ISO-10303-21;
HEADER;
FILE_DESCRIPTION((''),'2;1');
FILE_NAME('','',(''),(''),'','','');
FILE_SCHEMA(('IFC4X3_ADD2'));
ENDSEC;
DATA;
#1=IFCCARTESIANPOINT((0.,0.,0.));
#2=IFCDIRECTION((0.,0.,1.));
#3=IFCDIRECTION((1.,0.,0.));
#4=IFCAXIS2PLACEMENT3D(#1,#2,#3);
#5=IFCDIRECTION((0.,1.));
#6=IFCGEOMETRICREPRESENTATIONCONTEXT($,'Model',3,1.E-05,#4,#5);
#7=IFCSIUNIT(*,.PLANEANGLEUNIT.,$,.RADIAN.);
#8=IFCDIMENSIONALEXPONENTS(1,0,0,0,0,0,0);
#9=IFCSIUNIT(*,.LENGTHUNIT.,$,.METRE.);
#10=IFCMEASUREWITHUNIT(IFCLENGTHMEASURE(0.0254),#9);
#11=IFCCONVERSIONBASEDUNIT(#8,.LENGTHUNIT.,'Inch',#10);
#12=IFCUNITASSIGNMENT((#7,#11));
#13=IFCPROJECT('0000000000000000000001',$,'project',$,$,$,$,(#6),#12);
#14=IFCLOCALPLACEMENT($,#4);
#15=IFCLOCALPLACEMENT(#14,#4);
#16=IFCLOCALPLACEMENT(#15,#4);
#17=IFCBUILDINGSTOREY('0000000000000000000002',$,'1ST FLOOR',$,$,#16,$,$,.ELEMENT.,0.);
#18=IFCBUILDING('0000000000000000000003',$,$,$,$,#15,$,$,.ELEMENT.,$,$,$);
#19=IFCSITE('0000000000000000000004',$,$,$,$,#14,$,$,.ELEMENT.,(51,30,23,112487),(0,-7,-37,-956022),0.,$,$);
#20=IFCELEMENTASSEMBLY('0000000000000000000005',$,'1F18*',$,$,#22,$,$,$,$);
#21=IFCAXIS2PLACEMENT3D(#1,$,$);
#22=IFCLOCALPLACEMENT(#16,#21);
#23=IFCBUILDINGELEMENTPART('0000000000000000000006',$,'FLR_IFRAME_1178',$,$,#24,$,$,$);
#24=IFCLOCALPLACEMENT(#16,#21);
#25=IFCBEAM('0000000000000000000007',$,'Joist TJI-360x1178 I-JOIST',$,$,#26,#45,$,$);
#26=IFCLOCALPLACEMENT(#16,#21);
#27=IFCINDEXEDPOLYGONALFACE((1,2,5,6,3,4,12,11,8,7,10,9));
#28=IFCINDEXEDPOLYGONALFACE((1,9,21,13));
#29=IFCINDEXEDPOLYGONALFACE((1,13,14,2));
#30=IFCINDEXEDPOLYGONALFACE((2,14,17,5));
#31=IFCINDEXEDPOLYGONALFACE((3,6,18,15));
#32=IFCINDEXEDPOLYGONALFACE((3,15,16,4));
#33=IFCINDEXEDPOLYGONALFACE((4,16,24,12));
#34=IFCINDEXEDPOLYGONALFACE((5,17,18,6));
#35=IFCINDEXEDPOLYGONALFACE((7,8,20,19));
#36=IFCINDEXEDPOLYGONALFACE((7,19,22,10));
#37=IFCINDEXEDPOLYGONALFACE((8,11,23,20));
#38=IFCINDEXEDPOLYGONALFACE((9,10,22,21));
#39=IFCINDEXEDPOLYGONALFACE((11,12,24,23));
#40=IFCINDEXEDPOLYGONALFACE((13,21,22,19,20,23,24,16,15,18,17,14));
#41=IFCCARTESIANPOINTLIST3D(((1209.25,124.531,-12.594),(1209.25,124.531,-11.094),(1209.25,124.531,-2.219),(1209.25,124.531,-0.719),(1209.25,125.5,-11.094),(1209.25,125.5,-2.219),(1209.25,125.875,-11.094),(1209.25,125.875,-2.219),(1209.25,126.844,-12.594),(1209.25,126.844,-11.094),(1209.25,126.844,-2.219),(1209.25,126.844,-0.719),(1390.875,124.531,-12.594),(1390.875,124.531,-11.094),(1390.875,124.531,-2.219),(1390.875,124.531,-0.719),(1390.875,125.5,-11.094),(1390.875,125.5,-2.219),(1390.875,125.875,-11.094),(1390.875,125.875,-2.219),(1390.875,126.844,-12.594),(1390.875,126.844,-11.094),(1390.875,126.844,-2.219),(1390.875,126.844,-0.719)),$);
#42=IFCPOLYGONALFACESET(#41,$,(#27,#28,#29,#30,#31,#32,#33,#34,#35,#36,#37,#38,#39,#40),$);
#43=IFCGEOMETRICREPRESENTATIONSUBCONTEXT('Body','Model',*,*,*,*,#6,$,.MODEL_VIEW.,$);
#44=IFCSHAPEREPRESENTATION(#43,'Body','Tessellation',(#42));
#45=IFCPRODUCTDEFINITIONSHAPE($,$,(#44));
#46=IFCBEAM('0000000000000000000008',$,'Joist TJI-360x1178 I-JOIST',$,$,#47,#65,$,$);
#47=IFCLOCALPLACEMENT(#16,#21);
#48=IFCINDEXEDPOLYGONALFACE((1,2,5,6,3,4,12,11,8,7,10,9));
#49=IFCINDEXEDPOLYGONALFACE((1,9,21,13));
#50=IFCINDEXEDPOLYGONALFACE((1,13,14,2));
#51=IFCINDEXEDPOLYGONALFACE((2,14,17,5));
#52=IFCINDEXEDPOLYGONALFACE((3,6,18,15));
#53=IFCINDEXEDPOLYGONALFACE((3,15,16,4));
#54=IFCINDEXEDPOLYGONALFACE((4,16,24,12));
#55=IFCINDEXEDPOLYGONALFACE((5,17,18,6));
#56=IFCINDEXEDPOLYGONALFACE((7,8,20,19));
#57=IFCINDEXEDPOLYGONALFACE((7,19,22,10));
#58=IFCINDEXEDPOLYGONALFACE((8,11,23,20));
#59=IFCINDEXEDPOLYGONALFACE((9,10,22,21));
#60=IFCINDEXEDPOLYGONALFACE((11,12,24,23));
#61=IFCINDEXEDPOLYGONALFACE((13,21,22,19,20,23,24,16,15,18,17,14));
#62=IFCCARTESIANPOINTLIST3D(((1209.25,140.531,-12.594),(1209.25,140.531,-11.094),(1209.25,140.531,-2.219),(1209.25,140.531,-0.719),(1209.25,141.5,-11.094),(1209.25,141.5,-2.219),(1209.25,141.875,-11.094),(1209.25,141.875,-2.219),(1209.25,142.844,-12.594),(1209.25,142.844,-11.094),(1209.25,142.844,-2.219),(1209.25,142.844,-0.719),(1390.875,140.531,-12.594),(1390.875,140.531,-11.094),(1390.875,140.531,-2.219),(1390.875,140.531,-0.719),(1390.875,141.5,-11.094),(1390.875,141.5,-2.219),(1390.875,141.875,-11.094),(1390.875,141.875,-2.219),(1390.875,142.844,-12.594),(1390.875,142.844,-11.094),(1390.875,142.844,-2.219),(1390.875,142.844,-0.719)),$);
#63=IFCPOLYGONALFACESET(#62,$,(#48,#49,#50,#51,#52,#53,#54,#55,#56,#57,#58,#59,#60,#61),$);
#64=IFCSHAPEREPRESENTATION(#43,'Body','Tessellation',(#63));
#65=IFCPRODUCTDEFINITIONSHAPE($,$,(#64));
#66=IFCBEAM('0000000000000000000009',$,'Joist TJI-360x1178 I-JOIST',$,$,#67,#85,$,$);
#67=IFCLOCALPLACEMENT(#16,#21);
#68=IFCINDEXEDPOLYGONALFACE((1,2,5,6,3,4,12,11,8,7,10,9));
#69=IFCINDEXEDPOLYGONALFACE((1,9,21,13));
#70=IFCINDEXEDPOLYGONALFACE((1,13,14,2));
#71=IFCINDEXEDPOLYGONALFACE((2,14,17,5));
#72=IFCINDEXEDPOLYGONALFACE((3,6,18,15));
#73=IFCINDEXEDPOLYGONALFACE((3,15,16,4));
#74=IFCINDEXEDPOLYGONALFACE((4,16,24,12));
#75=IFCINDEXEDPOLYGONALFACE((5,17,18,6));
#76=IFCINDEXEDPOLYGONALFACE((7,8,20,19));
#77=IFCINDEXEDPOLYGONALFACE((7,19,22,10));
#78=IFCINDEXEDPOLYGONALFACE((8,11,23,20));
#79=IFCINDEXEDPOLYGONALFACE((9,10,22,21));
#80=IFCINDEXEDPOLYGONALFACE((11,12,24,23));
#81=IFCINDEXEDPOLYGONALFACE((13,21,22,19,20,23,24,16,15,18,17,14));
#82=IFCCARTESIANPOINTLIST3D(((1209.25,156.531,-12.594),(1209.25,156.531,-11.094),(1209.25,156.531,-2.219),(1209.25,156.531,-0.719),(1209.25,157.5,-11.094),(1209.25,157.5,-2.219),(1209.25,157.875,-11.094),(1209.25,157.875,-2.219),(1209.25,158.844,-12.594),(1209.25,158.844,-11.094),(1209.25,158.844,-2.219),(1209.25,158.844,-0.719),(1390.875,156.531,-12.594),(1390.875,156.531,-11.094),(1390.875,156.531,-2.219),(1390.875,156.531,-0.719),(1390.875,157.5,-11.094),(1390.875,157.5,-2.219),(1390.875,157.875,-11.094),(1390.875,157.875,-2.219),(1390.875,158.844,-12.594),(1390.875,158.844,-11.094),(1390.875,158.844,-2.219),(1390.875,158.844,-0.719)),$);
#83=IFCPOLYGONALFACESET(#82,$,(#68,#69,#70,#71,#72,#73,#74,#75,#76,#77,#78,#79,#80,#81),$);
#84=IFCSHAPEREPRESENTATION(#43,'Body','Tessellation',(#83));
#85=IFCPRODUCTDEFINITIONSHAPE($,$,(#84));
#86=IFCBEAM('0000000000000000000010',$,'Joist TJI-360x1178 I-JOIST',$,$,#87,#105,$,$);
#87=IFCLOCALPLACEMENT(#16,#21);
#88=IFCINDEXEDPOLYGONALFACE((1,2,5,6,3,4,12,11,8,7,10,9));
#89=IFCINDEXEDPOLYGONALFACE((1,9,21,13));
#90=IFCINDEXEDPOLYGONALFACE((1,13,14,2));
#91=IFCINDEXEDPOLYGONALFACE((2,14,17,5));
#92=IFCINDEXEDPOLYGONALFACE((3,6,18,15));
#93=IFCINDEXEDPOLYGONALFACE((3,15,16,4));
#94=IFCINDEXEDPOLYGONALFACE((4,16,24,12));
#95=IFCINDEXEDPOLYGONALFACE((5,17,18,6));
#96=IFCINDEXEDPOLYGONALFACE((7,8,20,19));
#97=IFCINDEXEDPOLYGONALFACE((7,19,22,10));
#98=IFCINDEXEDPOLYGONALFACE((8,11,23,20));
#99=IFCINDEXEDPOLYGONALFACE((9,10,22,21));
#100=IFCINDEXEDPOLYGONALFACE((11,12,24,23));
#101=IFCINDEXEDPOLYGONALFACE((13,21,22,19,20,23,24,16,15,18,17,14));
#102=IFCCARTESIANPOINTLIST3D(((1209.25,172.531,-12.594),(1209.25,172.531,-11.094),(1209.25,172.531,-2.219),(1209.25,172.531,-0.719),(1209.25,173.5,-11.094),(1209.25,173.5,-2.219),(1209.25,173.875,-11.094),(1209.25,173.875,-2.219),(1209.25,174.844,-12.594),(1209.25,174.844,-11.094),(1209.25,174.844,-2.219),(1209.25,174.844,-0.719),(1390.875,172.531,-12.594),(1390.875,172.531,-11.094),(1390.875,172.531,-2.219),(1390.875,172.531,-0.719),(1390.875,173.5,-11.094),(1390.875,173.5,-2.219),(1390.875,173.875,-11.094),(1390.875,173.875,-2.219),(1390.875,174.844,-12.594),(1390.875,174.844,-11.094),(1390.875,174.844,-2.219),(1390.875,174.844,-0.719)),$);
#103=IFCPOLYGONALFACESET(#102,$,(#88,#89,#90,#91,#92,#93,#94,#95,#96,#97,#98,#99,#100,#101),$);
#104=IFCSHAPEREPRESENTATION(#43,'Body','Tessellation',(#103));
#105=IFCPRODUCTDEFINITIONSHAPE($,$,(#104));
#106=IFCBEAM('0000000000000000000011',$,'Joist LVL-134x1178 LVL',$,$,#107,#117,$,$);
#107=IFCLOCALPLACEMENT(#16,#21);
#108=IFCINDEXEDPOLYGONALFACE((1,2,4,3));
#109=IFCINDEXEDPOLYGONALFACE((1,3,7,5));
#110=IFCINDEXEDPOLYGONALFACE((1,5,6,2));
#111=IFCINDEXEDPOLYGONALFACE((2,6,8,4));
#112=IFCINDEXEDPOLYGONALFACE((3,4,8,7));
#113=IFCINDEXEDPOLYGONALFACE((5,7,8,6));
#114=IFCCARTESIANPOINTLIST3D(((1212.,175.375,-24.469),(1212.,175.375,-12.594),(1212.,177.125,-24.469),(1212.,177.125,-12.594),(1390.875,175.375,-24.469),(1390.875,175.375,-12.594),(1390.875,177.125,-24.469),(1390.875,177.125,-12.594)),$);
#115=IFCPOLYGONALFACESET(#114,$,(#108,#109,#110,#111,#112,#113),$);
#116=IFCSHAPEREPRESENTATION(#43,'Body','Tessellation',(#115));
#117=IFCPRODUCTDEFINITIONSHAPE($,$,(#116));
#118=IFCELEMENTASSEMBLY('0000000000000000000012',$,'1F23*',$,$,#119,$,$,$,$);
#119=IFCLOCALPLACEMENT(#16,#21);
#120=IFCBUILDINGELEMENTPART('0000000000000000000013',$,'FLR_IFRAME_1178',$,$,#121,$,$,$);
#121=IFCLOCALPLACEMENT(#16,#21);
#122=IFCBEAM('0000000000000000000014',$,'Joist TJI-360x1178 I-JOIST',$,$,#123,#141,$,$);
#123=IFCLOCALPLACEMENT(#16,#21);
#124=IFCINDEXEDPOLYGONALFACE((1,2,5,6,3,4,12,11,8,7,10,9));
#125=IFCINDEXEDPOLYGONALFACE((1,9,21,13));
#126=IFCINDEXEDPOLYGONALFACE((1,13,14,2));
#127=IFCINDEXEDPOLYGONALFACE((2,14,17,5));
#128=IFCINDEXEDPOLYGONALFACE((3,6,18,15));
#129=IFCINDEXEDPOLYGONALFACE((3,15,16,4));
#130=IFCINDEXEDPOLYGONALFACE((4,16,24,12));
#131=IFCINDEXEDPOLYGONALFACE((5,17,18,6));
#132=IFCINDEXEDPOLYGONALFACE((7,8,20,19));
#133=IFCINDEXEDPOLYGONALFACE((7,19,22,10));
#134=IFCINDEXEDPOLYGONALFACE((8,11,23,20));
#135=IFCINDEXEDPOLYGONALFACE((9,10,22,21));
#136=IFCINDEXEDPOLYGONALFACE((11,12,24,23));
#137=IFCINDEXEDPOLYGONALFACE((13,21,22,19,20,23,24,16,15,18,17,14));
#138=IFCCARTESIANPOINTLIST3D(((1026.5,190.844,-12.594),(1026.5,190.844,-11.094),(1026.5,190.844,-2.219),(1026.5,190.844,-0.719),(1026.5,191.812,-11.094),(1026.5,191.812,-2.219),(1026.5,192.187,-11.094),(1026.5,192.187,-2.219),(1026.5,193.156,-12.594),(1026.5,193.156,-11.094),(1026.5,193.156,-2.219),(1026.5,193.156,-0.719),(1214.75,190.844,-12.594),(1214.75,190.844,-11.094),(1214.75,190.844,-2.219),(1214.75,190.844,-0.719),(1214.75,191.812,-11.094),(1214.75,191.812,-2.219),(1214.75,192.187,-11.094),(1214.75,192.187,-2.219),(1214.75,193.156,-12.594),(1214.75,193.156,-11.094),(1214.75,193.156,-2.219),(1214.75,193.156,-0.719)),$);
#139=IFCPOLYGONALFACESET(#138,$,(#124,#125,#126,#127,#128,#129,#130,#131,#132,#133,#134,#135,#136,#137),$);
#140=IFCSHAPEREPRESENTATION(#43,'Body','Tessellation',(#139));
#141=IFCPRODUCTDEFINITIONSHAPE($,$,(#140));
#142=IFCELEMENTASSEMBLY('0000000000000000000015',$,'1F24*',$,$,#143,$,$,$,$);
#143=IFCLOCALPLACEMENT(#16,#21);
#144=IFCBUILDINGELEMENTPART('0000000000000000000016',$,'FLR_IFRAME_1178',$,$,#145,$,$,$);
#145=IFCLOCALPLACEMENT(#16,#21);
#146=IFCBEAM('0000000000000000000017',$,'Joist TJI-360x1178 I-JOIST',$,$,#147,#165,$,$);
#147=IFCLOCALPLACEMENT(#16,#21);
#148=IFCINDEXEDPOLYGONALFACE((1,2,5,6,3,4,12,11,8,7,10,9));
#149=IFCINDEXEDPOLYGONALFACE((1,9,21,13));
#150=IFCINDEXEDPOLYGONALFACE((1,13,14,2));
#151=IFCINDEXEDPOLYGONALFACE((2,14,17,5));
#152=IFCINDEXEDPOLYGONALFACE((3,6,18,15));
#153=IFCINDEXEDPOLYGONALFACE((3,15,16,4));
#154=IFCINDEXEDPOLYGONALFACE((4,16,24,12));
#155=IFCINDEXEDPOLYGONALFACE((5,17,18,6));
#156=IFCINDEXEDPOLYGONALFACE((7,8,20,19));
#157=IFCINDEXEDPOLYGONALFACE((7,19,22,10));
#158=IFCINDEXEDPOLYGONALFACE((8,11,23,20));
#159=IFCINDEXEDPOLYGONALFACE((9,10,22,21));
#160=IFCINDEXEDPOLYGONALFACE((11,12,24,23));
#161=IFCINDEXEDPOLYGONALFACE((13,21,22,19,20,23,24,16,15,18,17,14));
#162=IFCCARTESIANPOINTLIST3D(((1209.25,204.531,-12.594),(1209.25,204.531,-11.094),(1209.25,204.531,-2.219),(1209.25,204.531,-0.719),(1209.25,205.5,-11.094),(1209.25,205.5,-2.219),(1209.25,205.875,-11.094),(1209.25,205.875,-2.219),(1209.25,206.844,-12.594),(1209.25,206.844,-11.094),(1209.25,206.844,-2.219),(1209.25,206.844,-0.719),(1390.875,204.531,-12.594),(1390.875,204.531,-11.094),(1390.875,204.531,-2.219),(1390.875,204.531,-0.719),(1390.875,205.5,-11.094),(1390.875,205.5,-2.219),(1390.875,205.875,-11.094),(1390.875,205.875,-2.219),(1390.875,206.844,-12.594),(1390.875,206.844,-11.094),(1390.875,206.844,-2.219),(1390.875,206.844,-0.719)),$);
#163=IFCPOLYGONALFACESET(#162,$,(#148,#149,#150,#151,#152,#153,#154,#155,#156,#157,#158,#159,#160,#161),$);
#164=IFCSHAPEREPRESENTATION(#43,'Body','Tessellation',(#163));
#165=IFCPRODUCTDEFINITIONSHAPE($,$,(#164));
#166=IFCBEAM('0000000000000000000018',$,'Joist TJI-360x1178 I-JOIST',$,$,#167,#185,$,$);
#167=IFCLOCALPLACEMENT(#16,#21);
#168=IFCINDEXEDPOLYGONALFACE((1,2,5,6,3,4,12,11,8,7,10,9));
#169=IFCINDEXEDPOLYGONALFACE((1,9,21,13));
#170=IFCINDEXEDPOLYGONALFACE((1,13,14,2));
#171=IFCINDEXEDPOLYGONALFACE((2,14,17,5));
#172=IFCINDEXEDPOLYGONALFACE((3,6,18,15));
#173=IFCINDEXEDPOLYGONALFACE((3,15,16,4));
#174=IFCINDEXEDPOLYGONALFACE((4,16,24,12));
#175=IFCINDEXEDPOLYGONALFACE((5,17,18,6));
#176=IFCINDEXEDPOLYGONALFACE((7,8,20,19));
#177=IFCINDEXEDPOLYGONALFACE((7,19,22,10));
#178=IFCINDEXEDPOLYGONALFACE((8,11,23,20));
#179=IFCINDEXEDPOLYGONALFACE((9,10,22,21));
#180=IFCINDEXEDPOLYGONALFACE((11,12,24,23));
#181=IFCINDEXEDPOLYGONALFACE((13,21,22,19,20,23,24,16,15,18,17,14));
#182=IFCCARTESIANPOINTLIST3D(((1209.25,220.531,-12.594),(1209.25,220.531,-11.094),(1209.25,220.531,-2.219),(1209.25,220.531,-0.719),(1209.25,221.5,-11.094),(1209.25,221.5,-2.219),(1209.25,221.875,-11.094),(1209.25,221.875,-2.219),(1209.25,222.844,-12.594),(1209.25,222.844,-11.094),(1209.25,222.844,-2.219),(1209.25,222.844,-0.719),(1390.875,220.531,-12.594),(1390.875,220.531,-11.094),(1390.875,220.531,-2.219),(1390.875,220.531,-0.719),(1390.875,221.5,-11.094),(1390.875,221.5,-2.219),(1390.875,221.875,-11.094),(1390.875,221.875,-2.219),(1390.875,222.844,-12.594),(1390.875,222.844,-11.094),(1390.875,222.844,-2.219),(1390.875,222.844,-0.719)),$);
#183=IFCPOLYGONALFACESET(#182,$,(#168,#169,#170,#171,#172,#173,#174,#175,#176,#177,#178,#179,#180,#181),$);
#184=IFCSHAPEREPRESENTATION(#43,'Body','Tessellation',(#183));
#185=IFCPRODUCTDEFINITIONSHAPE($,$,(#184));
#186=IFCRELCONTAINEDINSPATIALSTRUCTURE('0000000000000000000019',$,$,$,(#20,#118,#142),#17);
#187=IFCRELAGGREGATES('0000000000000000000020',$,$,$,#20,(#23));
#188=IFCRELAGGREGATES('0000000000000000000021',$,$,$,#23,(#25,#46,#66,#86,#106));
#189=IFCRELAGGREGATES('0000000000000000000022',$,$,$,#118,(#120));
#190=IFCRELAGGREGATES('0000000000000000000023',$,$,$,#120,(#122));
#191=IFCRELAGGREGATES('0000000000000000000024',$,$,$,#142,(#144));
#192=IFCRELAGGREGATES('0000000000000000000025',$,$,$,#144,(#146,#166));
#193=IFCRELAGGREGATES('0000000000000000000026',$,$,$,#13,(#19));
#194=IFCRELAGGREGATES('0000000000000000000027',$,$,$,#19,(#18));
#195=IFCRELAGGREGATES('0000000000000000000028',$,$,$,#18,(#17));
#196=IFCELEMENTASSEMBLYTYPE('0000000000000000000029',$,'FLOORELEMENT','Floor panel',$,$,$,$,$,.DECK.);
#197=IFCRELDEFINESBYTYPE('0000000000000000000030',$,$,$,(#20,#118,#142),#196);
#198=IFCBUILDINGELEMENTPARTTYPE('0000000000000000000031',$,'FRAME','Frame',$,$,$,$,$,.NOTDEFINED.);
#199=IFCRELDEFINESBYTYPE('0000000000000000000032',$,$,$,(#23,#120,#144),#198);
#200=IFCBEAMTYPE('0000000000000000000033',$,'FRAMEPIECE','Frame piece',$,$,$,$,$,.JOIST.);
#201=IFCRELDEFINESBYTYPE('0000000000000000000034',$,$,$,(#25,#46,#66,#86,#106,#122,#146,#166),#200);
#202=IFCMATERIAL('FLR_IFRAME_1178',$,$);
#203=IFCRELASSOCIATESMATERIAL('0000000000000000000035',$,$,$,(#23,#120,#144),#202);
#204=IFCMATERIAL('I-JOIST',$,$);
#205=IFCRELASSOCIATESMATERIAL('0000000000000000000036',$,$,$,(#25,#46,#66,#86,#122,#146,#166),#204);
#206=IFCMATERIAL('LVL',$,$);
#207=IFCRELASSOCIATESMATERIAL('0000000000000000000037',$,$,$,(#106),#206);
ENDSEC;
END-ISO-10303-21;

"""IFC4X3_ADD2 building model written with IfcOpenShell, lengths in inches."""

from ifc_helpers import new_model, entity, si_unit, converted_unit, direction, frame, origin_with_axes, origin_2d_with_axis, place, context, subcontext, project, spatial, rectangle, i_section, extrude, material, type_object, element, aggregate, save


model = new_model("IFC4X3_ADD2")

# Units and contexts
model_context = context("Model", 3, precision=1e-05, world=origin_with_axes(), true_north=direction((0.0, 1.0)))
body_context = subcontext(model_context, "Body", "Model", "MODEL_VIEW")
ifc_project = project(units=[si_unit("PLANEANGLEUNIT", "RADIAN"), converted_unit("LENGTHUNIT", "Inch", entity("IfcLengthMeasure", 0.0254), si_unit("LENGTHUNIT", "METRE"), dimensions=[1, 0, 0, 0, 0, 0, 0])], contexts=[model_context])

# Site, building, storey
site_placement = place(None, origin_with_axes())
site = spatial("IfcSite", under=ifc_project, at=site_placement, CompositionType="ELEMENT", RefLatitude=(51, 30, 23, 112487), RefLongitude=(0, -7, -37, -956022), RefElevation=0.0)
building_placement = place(site_placement, origin_with_axes())
building = spatial("IfcBuilding", under=site, at=building_placement, CompositionType="ELEMENT")
storey_placement = place(building_placement, origin_with_axes())
storey = spatial("IfcBuildingStorey", under=building, at=storey_placement, Name="1ST FLOOR", CompositionType="ELEMENT", Elevation=0.0)

# Shared definitions
building_element_part_type = type_object("IfcBuildingElementPartType", Name="FRAME", Description="Frame", PredefinedType="NOTDEFINED")

# Shared definitions
element_assembly_type_1 = type_object("IfcElementAssemblyType", Name="FLOORELEMENT", Description="Floor panel", PredefinedType="DECK")
ifc_material_1 = material(Name="FLR_IFRAME_1178")
ifc_material_2 = material(Name="I-JOIST")
beam_type_1 = type_object("IfcBeamType", Name="FRAMEPIECE", Description="Frame piece", PredefinedType="JOIST")

# Element assembly, building element part, beams
assembly_1_placement = place(storey_placement, origin_with_axes())
assembly_1 = element("IfcElementAssembly", 1, at=assembly_1_placement, inside=storey, type_object=element_assembly_type_1, Name="1F18*")
building_element_part_1_placement = place(storey_placement, origin_with_axes())
building_element_part_1 = element("IfcBuildingElementPart", 2, at=building_element_part_1_placement, type_object=building_element_part_type, material=ifc_material_1, Name="FLR_IFRAME_1178")
aggregate(assembly_1, [building_element_part_1])
beam_1_placement = place(storey_placement, frame((1209.25, 125.688, -6.656), z_axis=(1.0, 0.0, 0.0), x_axis=(0.0, 1.0, 0.0)))
beam_1 = element("IfcBeam", 3, at=beam_1_placement, type_object=beam_type_1, material=ifc_material_2, Name="Joist TJI-360x1178 I-JOIST", context=body_context, shape_type="SweptSolid", body=[
    extrude(i_section(OverallWidth=2.313, OverallDepth=11.875, WebThickness=0.375, FlangeThickness=1.5, at=origin_2d_with_axis()), origin_with_axes(), (0.0, 0.0, 1.0), 181.625),
])
beam_2_placement = place(storey_placement, frame((1209.25, 141.688, -6.656), z_axis=(1.0, 0.0, 0.0), x_axis=(0.0, 1.0, 0.0)))
beam_2 = element("IfcBeam", 4, at=beam_2_placement, type_object=beam_type_1, material=ifc_material_2, Name="Joist TJI-360x1178 I-JOIST", context=body_context, shape_type="SweptSolid", body=[
    extrude(i_section(OverallWidth=2.313, OverallDepth=11.875, WebThickness=0.375, FlangeThickness=1.5, at=origin_2d_with_axis()), origin_with_axes(), (0.0, 0.0, 1.0), 181.625),
])
beam_3_placement = place(storey_placement, frame((1209.25, 157.688, -6.656), z_axis=(1.0, 0.0, 0.0), x_axis=(0.0, 1.0, 0.0)))
beam_3 = element("IfcBeam", 5, at=beam_3_placement, type_object=beam_type_1, material=ifc_material_2, Name="Joist TJI-360x1178 I-JOIST", context=body_context, shape_type="SweptSolid", body=[
    extrude(i_section(OverallWidth=2.313, OverallDepth=11.875, WebThickness=0.375, FlangeThickness=1.5, at=origin_2d_with_axis()), origin_with_axes(), (0.0, 0.0, 1.0), 181.625),
])
beam_4_placement = place(storey_placement, frame((1209.25, 173.688, -6.656), z_axis=(1.0, 0.0, 0.0), x_axis=(0.0, 1.0, 0.0)))
beam_4 = element("IfcBeam", 6, at=beam_4_placement, type_object=beam_type_1, material=ifc_material_2, Name="Joist TJI-360x1178 I-JOIST", context=body_context, shape_type="SweptSolid", body=[
    extrude(i_section(OverallWidth=2.313, OverallDepth=11.875, WebThickness=0.375, FlangeThickness=1.5, at=origin_2d_with_axis()), origin_with_axes(), (0.0, 0.0, 1.0), 181.625),
])
ifc_material_3 = material(Name="LVL")
beam_5_placement = place(storey_placement, frame((1212.0, 176.25, -18.531), z_axis=(1.0, 0.0, 0.0), x_axis=(0.0, 1.0, 0.0)))
beam_5 = element("IfcBeam", 7, at=beam_5_placement, type_object=beam_type_1, material=ifc_material_3, Name="Joist LVL-134x1178 LVL", context=body_context, shape_type="SweptSolid", body=[
    extrude(rectangle(XDim=1.75, YDim=11.875, at=origin_2d_with_axis()), origin_with_axes(), (0.0, 0.0, 1.0), 178.875),
])
aggregate(building_element_part_1, [beam_1, beam_2, beam_3, beam_4, beam_5])

# Element assembly, building element part, beam
assembly_2_placement = place(storey_placement, origin_with_axes())
assembly_2 = element("IfcElementAssembly", 8, at=assembly_2_placement, inside=storey, type_object=element_assembly_type_1, Name="1F23*")
building_element_part_2_placement = place(storey_placement, origin_with_axes())
building_element_part_2 = element("IfcBuildingElementPart", 9, at=building_element_part_2_placement, type_object=building_element_part_type, material=ifc_material_1, Name="FLR_IFRAME_1178")
aggregate(assembly_2, [building_element_part_2])
beam_6_placement = place(storey_placement, frame((1214.75, 192.0, -6.656), z_axis=(-1.0, 0.0, 0.0), x_axis=(0.0, -1.0, 0.0)))
beam_6 = element("IfcBeam", 10, at=beam_6_placement, type_object=beam_type_1, material=ifc_material_2, Name="Joist TJI-360x1178 I-JOIST", context=body_context, shape_type="SweptSolid", body=[
    extrude(i_section(OverallWidth=2.313, OverallDepth=11.875, WebThickness=0.375, FlangeThickness=1.5, at=origin_2d_with_axis()), origin_with_axes(), (0.0, 0.0, 1.0), 188.25),
])
aggregate(building_element_part_2, [beam_6])

# Element assembly, building element part, beams
assembly_3_placement = place(storey_placement, origin_with_axes())
assembly_3 = element("IfcElementAssembly", 11, at=assembly_3_placement, inside=storey, type_object=element_assembly_type_1, Name="1F24*")
building_element_part_3_placement = place(storey_placement, origin_with_axes())
building_element_part_3 = element("IfcBuildingElementPart", 12, at=building_element_part_3_placement, type_object=building_element_part_type, material=ifc_material_1, Name="FLR_IFRAME_1178")
aggregate(assembly_3, [building_element_part_3])
beam_7_placement = place(storey_placement, frame((1209.25, 205.688, -6.656), z_axis=(1.0, 0.0, 0.0), x_axis=(0.0, 1.0, 0.0)))
beam_7 = element("IfcBeam", 13, at=beam_7_placement, type_object=beam_type_1, material=ifc_material_2, Name="Joist TJI-360x1178 I-JOIST", context=body_context, shape_type="SweptSolid", body=[
    extrude(i_section(OverallWidth=2.313, OverallDepth=11.875, WebThickness=0.375, FlangeThickness=1.5, at=origin_2d_with_axis()), origin_with_axes(), (0.0, 0.0, 1.0), 181.625),
])
beam_8_placement = place(storey_placement, frame((1209.25, 221.688, -6.656), z_axis=(1.0, 0.0, 0.0), x_axis=(0.0, 1.0, 0.0)))
beam_8 = element("IfcBeam", 14, at=beam_8_placement, type_object=beam_type_1, material=ifc_material_2, Name="Joist TJI-360x1178 I-JOIST", context=body_context, shape_type="SweptSolid", body=[
    extrude(i_section(OverallWidth=2.313, OverallDepth=11.875, WebThickness=0.375, FlangeThickness=1.5, at=origin_2d_with_axis()), origin_with_axes(), (0.0, 0.0, 1.0), 181.625),
])
aggregate(building_element_part_3, [beam_7, beam_8])

save(model, "model.ifc")
